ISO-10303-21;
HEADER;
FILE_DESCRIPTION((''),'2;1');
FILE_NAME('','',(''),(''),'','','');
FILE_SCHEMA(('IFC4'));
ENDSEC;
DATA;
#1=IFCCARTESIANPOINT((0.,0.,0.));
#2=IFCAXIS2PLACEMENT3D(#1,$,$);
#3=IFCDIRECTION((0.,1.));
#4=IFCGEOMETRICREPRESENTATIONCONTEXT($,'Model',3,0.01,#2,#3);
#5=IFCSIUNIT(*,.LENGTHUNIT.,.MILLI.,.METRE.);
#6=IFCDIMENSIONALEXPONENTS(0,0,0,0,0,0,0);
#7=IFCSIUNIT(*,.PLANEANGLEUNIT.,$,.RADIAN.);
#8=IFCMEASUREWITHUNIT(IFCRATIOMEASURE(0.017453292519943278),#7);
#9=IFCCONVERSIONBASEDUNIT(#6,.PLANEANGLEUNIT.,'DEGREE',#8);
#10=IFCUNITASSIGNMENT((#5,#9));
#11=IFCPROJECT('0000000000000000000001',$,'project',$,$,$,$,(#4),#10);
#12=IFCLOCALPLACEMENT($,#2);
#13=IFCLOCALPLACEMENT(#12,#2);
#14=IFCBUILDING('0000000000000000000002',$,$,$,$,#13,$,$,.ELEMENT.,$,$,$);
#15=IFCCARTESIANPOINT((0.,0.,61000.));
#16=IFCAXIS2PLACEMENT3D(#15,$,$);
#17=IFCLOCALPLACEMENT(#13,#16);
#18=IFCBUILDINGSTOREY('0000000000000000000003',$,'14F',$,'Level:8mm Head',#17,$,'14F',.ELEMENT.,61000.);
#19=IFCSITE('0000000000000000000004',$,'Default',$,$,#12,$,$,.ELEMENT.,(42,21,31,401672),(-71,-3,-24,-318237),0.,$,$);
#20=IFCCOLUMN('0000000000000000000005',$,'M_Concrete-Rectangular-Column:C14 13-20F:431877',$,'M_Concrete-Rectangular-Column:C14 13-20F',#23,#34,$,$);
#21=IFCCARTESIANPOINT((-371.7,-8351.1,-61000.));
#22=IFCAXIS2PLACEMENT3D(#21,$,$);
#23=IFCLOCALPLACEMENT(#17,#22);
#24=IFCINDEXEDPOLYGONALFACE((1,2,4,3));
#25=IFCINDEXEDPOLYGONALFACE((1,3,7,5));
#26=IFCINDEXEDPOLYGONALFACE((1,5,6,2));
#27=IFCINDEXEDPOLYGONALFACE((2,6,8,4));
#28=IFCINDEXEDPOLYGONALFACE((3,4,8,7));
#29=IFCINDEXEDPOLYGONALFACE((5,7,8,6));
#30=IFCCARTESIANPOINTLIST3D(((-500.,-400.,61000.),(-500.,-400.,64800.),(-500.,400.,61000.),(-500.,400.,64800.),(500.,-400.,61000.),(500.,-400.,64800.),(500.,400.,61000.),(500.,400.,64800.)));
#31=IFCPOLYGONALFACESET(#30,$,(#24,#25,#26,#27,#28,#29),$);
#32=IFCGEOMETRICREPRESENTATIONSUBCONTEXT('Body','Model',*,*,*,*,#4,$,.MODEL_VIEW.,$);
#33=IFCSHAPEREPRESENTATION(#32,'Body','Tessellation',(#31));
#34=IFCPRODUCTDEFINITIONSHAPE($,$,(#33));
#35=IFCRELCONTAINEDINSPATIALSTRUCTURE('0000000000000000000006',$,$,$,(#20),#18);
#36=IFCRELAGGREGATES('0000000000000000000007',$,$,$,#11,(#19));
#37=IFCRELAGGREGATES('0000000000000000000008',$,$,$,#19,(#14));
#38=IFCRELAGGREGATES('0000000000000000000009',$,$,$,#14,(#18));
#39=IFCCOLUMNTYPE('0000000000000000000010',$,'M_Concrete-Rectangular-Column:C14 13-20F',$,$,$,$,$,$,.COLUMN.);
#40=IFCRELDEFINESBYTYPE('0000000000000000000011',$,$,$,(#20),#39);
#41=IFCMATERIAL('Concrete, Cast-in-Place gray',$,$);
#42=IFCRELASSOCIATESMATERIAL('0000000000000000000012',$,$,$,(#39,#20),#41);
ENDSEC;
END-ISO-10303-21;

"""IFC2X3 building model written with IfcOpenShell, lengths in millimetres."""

from ifc_helpers import new_model, entity, si_unit, converted_unit, direction, frame, origin, origin_2d_with_axis, place, context, subcontext, project, spatial, rectangle, extrude, source, transform, mapped, material, type_object, type_shapes, element, save


model = new_model("IFC2X3")

# Units and contexts
model_context = context("Model", 3, precision=0.01, world=origin(), true_north=direction((0.0, 1.0)))
body_context = subcontext(model_context, "Body", "Model", "MODEL_VIEW")
ifc_project = project(units=[si_unit("LENGTHUNIT", "METRE", prefix="MILLI"), converted_unit("PLANEANGLEUNIT", "DEGREE", entity("IfcRatioMeasure", 0.017453292519943278), si_unit("PLANEANGLEUNIT", "RADIAN"), dimensions=[0, 0, 0, 0, 0, 0, 0])], contexts=[model_context])

# Site, building, storey
site_placement = place(None, origin())
site = spatial("IfcSite", under=ifc_project, at=site_placement, Name="Default", CompositionType="ELEMENT", RefLatitude=(42, 21, 31, 401672), RefLongitude=(-71, -3, -24, -318237), RefElevation=0.0)
building_placement = place(site_placement, origin())
building = spatial("IfcBuilding", under=site, at=building_placement, CompositionType="ELEMENT")
storey_placement = place(building_placement, frame((0.0, 0.0, 61000.0)))
storey = spatial("IfcBuildingStorey", under=building, at=storey_placement, Name="14F", ObjectType="Level:8mm Head", LongName="14F", CompositionType="ELEMENT", Elevation=61000.0)

# Column
ifc_material_1 = material(Name="Concrete, Cast-in-Place gray")
column_type = type_object("IfcColumnType", Name="M_Concrete-Rectangular-Column:C14 13-20F", PredefinedType="COLUMN", material=ifc_material_1)
shared_shape = source(origin(), body_context, "Body", "SweptSolid", [
    extrude(rectangle(XDim=800.0, YDim=1000.0, at=origin_2d_with_axis()), frame((0.0, 0.0, 61000.0), z_axis=(0.0, 0.0, 1.0), x_axis=(0.0, -1.0, 0.0)), (0.0, 0.0, 1.0), 3800.0),
])
type_shapes(column_type, [shared_shape])
column_placement = place(storey_placement, frame((-371.7, -8351.1, -61000.0)))
element("IfcColumn", 1, at=column_placement, inside=storey, type_object=column_type, material=ifc_material_1, Name="M_Concrete-Rectangular-Column:C14 13-20F:431877", ObjectType="M_Concrete-Rectangular-Column:C14 13-20F", context=body_context, shape_type="MappedRepresentation", body=[
    mapped(shared_shape, transform((0.0, 0.0, 0.0), scale=1.0)),
])

save(model, "model.ifc")
